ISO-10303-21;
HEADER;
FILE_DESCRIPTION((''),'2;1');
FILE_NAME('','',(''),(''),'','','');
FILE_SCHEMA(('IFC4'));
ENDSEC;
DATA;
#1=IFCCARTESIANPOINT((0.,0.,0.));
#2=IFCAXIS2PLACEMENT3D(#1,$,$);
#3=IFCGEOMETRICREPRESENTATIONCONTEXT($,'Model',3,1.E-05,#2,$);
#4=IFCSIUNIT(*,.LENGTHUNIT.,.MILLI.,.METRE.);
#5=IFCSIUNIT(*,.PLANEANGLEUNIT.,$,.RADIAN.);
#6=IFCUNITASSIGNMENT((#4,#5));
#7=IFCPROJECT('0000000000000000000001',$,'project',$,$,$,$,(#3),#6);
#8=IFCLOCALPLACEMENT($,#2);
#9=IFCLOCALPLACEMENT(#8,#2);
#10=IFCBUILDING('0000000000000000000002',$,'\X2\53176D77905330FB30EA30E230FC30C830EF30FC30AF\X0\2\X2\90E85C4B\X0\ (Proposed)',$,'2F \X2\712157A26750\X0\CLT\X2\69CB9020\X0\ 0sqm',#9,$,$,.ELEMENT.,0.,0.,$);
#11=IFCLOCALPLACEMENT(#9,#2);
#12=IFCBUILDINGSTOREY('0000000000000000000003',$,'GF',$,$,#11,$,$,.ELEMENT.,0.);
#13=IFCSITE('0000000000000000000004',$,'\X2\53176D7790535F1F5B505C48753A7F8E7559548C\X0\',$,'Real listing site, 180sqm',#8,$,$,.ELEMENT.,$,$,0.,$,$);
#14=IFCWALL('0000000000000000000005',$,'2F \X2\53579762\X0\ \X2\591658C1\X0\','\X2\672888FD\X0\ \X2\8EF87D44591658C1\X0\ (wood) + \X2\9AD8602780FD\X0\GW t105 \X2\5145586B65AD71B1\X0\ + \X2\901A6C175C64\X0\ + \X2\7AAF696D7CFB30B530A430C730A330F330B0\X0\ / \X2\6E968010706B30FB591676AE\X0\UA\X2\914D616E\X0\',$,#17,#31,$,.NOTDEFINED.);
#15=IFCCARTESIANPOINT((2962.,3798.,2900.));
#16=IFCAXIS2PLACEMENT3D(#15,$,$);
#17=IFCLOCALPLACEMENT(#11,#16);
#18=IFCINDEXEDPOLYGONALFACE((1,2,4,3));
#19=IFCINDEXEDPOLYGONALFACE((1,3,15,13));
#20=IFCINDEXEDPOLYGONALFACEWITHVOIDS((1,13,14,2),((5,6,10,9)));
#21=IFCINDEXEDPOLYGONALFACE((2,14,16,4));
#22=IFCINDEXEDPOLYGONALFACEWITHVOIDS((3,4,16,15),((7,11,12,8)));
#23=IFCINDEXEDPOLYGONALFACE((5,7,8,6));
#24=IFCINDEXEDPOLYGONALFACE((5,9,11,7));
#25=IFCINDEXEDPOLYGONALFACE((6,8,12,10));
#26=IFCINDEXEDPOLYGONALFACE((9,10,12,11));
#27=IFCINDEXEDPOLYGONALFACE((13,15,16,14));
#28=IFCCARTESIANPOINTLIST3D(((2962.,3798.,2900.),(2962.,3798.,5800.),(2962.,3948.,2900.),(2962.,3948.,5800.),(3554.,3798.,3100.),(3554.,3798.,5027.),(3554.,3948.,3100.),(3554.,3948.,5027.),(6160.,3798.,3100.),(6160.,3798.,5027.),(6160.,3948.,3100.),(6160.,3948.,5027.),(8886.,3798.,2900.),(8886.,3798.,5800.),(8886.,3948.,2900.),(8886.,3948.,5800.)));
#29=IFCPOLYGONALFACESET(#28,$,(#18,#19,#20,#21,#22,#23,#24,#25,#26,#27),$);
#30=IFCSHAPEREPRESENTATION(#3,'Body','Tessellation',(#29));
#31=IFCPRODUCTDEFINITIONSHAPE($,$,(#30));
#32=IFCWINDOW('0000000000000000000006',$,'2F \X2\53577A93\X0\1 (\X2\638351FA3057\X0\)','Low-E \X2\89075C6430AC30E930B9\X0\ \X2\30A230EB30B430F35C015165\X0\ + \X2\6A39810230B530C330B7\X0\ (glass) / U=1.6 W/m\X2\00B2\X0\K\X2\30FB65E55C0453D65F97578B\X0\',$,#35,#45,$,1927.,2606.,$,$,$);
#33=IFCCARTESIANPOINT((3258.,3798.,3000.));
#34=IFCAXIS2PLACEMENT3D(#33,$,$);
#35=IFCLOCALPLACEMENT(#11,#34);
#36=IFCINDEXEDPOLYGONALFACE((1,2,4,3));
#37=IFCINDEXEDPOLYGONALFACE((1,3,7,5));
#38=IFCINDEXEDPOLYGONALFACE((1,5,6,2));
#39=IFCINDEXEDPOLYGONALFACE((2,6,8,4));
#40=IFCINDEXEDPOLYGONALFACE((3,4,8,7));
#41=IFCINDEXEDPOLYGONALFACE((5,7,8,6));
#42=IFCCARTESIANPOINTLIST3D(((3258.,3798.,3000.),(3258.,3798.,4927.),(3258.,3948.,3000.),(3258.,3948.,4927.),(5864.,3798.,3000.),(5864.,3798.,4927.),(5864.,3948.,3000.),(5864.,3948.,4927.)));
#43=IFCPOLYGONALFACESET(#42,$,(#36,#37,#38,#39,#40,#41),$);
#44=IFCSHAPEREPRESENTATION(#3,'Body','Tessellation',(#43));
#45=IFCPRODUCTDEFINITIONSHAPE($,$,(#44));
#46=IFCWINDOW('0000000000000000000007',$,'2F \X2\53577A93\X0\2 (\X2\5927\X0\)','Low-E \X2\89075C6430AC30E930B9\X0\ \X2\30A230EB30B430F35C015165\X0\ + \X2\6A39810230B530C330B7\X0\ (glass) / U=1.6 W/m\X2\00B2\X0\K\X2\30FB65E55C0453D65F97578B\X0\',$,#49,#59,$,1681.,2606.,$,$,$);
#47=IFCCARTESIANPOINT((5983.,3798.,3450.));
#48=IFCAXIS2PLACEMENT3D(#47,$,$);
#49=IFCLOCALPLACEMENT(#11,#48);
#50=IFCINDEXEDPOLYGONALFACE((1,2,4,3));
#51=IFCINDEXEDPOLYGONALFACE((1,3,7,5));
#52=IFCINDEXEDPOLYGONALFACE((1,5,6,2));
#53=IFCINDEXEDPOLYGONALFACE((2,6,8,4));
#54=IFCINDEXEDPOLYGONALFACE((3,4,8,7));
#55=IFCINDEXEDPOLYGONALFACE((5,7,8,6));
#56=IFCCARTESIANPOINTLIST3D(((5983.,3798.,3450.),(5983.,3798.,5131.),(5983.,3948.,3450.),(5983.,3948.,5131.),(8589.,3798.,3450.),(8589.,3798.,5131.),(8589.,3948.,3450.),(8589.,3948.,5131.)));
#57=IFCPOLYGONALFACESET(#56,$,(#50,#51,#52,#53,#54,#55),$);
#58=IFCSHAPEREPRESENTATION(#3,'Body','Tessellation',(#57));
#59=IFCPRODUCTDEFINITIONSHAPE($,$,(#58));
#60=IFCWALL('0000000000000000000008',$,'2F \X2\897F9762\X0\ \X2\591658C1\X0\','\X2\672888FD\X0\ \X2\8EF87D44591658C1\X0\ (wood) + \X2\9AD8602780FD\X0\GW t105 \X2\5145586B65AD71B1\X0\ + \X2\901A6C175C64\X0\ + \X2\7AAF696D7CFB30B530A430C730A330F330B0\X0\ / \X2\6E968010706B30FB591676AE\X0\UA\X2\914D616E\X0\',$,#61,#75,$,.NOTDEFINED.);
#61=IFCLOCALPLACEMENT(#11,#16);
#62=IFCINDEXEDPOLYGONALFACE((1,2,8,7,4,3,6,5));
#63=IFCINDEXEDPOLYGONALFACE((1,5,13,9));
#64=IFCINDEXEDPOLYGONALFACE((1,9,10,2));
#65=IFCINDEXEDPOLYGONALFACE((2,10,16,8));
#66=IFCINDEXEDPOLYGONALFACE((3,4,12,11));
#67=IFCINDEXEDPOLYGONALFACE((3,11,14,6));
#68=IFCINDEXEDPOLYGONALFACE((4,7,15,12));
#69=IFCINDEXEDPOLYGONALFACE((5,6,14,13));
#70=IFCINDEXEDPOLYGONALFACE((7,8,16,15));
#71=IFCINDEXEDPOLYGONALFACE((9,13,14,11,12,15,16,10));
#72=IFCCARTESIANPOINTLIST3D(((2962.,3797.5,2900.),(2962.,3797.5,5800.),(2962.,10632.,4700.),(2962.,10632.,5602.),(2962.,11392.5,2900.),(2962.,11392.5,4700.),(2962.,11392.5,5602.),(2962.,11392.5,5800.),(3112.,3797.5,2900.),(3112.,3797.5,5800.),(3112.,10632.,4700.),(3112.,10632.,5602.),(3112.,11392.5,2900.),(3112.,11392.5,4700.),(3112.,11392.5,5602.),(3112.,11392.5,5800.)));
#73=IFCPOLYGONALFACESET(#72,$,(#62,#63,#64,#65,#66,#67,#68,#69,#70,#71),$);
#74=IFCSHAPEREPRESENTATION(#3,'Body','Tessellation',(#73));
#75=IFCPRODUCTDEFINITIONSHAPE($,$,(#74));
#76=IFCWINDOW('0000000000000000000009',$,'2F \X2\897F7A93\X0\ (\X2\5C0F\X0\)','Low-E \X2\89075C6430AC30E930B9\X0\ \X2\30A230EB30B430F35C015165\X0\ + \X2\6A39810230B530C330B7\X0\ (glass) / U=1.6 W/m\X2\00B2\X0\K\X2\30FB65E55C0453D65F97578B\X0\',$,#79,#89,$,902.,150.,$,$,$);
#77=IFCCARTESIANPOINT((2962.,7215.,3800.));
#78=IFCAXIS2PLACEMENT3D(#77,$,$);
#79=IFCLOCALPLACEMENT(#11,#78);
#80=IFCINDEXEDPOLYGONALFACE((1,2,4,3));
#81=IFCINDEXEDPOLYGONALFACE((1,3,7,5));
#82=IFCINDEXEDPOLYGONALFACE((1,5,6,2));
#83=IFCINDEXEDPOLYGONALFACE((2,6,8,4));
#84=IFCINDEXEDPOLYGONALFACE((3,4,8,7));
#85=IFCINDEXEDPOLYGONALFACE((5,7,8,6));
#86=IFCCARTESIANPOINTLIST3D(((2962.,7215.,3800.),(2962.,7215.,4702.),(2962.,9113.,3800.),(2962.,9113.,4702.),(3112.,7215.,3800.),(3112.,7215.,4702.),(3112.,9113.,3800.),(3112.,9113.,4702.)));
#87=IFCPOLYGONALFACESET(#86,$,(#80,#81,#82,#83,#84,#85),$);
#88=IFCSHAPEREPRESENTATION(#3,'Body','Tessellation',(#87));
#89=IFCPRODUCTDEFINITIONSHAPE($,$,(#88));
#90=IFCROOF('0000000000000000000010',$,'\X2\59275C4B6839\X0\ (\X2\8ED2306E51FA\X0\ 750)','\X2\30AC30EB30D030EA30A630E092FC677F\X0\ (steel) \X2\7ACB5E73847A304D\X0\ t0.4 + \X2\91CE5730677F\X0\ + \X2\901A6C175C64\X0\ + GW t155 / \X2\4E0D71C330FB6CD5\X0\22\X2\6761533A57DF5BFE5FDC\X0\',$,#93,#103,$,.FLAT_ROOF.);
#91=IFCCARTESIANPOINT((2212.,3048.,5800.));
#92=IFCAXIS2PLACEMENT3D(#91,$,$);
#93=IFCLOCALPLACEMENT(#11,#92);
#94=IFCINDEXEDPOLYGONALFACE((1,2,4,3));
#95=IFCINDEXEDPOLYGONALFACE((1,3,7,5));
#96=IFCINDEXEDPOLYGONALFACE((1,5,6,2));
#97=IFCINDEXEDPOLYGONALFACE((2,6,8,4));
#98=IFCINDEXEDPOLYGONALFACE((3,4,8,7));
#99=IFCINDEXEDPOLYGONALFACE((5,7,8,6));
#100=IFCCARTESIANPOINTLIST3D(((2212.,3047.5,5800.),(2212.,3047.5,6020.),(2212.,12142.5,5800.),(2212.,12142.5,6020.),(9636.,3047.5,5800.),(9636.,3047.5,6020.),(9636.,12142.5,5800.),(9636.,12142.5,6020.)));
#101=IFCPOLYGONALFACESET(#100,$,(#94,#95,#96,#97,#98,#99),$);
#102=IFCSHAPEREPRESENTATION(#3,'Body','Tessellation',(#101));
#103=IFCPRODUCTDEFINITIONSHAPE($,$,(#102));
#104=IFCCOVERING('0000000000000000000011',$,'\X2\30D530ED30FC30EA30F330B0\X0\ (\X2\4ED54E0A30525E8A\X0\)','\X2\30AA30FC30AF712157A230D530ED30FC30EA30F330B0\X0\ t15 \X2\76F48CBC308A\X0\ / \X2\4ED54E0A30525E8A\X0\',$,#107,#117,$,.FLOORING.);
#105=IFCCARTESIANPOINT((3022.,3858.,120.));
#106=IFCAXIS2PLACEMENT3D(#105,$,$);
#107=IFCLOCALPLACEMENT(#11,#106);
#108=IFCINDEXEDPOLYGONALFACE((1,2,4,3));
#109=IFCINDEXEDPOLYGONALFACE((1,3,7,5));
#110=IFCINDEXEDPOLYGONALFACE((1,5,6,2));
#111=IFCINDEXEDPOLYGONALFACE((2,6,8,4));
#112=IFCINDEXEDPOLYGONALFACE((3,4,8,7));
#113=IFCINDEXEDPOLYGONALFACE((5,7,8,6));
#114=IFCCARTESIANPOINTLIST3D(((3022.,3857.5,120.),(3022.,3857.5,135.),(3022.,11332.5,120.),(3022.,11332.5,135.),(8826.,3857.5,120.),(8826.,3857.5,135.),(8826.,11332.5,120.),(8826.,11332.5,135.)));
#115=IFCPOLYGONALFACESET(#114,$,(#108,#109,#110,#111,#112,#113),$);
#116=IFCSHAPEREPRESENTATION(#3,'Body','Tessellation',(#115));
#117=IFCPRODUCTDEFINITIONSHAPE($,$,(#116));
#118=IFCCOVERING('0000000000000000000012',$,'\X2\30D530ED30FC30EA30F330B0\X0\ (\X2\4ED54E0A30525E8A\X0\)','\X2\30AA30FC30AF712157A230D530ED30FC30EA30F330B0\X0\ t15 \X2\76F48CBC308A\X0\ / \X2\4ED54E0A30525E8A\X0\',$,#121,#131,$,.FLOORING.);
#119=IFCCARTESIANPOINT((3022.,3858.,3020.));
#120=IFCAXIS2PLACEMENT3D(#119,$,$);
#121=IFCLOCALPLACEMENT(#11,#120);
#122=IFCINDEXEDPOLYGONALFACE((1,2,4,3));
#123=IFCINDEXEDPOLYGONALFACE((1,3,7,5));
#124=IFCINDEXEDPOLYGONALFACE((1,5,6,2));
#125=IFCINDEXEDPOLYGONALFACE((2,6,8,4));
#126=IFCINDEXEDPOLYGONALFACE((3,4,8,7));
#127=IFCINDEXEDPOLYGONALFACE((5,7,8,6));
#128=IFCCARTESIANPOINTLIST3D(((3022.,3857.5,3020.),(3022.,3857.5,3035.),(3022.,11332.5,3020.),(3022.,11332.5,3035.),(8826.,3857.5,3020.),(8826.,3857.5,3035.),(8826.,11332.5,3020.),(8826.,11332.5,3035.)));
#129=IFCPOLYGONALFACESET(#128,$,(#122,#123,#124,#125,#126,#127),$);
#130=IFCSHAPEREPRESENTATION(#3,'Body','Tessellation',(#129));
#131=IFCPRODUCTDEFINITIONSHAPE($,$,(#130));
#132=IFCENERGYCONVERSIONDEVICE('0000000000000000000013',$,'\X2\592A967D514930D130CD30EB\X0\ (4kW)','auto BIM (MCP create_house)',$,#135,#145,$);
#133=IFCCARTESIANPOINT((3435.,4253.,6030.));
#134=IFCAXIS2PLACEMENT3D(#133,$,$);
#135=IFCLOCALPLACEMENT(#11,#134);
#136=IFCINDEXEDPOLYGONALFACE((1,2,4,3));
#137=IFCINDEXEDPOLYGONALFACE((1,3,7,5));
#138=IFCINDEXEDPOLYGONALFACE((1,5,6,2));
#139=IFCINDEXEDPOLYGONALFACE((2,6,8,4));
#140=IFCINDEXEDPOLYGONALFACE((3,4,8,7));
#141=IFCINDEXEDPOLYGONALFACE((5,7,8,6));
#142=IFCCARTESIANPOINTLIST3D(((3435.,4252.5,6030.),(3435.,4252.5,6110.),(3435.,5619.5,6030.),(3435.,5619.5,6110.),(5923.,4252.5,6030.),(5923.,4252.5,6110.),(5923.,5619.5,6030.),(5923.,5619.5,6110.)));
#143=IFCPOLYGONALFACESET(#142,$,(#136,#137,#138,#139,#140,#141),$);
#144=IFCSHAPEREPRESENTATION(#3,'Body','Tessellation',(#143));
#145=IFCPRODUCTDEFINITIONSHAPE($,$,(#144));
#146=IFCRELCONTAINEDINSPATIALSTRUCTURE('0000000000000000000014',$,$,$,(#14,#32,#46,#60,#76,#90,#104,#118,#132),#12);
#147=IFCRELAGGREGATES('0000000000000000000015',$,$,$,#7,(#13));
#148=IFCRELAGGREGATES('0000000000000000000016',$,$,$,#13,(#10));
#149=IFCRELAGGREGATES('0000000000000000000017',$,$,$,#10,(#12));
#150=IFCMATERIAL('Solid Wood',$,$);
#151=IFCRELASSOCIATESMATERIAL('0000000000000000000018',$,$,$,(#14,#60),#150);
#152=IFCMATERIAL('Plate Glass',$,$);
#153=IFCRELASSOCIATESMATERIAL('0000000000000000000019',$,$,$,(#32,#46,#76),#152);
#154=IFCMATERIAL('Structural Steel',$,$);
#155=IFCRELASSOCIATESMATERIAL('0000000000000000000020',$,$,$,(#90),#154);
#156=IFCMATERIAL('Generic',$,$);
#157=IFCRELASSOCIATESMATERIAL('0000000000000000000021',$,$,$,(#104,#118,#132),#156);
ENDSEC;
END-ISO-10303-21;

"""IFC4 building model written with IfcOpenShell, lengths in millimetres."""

from ifc_helpers import new_model, si_unit, frame, frame_2d, origin, place, context, project, spatial, rectangle, extrude, material, element, fill, save


model = new_model("IFC4")

# Units and contexts
model_context = context("Model", 3, precision=1e-05, world=origin())
ifc_project = project(units=[si_unit("LENGTHUNIT", "METRE", prefix="MILLI"), si_unit("PLANEANGLEUNIT", "RADIAN")], contexts=[model_context])

# Site, building, storey
site_placement = place(None, origin())
site = spatial("IfcSite", under=ifc_project, at=site_placement, Name="北海道弟子屈町美留和", ObjectType="Real listing site, 180sqm", CompositionType="ELEMENT", RefElevation=0.0)
building_placement = place(site_placement, origin())
building = spatial("IfcBuilding", under=site, at=building_placement, Name="北海道・リモートワーク2部屋 (Proposed)", ObjectType="2F 無垢材CLT構造 0sqm", CompositionType="ELEMENT", ElevationOfRefHeight=0.0, ElevationOfTerrain=0.0)
storey_placement = place(building_placement, origin())
storey = spatial("IfcBuildingStorey", under=building, at=storey_placement, Name="GF", CompositionType="ELEMENT", Elevation=0.0)

# Shared definitions
ifc_material_1 = material(Name="Solid Wood")

# Shared definitions
ifc_material_2 = material(Name="Plate Glass")

# Wall, openings, windows
wall_1_placement = place(storey_placement, frame((2962.0, 3798.0, 2900.0)))
wall_1 = element("IfcWall", 1, at=wall_1_placement, inside=storey, material=ifc_material_1, Name="2F 南面 外壁", Description="木製 軸組外壁 (wood) + 高性能GW t105 充填断熱 + 通気層 + 窯業系サイディング / 準耐火・外皮UA配慮", PredefinedType="NOTDEFINED", context=model_context, shape_type="SweptSolid", body=[
    extrude(rectangle(XDim=5924.0, YDim=150.0, at=frame_2d((2962.0, 75.0))), frame((2962.0, 3798.0, 2900.0)), (0.0, 0.0, 1.0), 2900.0),
])
opening_1_placement = place(storey_placement, frame((3258.0, 3798.0, 3000.0)))
opening_1 = element("IfcOpeningElement", 2, at=opening_1_placement, cuts=wall_1, PredefinedType="NOTDEFINED", context=model_context, shape_type="SweptSolid", body=[
    extrude(rectangle(XDim=2606.0, YDim=150.0, at=frame_2d((1303.0, 75.0))), frame((3258.0, 3798.0, 3000.0)), (0.0, 0.0, 1.0), 1927.0),
])
opening_2_placement = place(storey_placement, frame((5983.0, 3798.0, 3450.0)))
opening_2 = element("IfcOpeningElement", 3, at=opening_2_placement, cuts=wall_1, PredefinedType="NOTDEFINED", context=model_context, shape_type="SweptSolid", body=[
    extrude(rectangle(XDim=2606.0, YDim=150.0, at=frame_2d((1303.0, 75.0))), frame((5983.0, 3798.0, 3450.0)), (0.0, 0.0, 1.0), 1681.0),
])
window_1_placement = place(storey_placement, frame((3258.0, 3798.0, 3000.0)))
window_1 = element("IfcWindow", 4, at=window_1_placement, inside=storey, material=ifc_material_2, Name="2F 南窓1 (掃出し)", Description="Low-E 複層ガラス アルゴン封入 + 樹脂サッシ (glass) / U=1.6 W/m²K・日射取得型", OverallHeight=1927.0, OverallWidth=2606.0, context=model_context, shape_type="SweptSolid", body=[
    extrude(rectangle(XDim=2606.0, YDim=150.0, at=frame_2d((1303.0, 75.0))), frame((3258.0, 3798.0, 3000.0)), (0.0, 0.0, 1.0), 1927.0),
])
fill(opening_1, window_1)
window_2_placement = place(storey_placement, frame((5983.0, 3798.0, 3450.0)))
window_2 = element("IfcWindow", 5, at=window_2_placement, inside=storey, material=ifc_material_2, Name="2F 南窓2 (大)", Description="Low-E 複層ガラス アルゴン封入 + 樹脂サッシ (glass) / U=1.6 W/m²K・日射取得型", OverallHeight=1681.0, OverallWidth=2606.0, context=model_context, shape_type="SweptSolid", body=[
    extrude(rectangle(XDim=2606.0, YDim=150.0, at=frame_2d((1303.0, 75.0))), frame((5983.0, 3798.0, 3450.0)), (0.0, 0.0, 1.0), 1681.0),
])
fill(opening_2, window_2)

# Wall, opening, window
wall_2_placement = place(storey_placement, frame((2962.0, 3798.0, 2900.0)))
wall_2 = element("IfcWall", 6, at=wall_2_placement, inside=storey, material=ifc_material_1, Name="2F 西面 外壁", Description="木製 軸組外壁 (wood) + 高性能GW t105 充填断熱 + 通気層 + 窯業系サイディング / 準耐火・外皮UA配慮", PredefinedType="NOTDEFINED", context=model_context, shape_type="SweptSolid", body=[
    extrude(rectangle(XDim=150.0, YDim=7595.0, at=frame_2d((75.0, 3797.0))), frame((2962.0, 3798.0, 2900.0)), (0.0, 0.0, 1.0), 2900.0),
])
opening_3_placement = place(storey_placement, frame((2962.0, 7215.0, 3800.0)))
opening_3 = element("IfcOpeningElement", 7, at=opening_3_placement, cuts=wall_2, PredefinedType="NOTDEFINED", context=model_context, shape_type="SweptSolid", body=[
    extrude(rectangle(XDim=150.0, YDim=1898.0, at=frame_2d((75.0, 949.0))), frame((2962.0, 7215.0, 3800.0)), (0.0, 0.0, 1.0), 902.0),
])
window_3_placement = place(storey_placement, frame((2962.0, 7215.0, 3800.0)))
window_3 = element("IfcWindow", 8, at=window_3_placement, inside=storey, material=ifc_material_2, Name="2F 西窓 (小)", Description="Low-E 複層ガラス アルゴン封入 + 樹脂サッシ (glass) / U=1.6 W/m²K・日射取得型", OverallHeight=902.0, OverallWidth=150.0, context=model_context, shape_type="SweptSolid", body=[
    extrude(rectangle(XDim=150.0, YDim=1898.0, at=frame_2d((75.0, 949.0))), frame((2962.0, 7215.0, 3800.0)), (0.0, 0.0, 1.0), 902.0),
])
fill(opening_3, window_3)

# Roof
ifc_material_3 = material(Name="Structural Steel")
roof_placement = place(storey_placement, frame((2212.0, 3048.0, 5800.0)))
element("IfcRoof", 9, at=roof_placement, inside=storey, material=ifc_material_3, Name="大屋根 (軒の出 750)", Description="ガルバリウム鋼板 (steel) 立平葺き t0.4 + 野地板 + 通気層 + GW t155 / 不燃・法22条区域対応", PredefinedType="FLAT_ROOF", context=model_context, shape_type="SweptSolid", body=[
    extrude(rectangle(XDim=7424.0, YDim=9095.0, at=frame_2d((3712.0, 4547.0))), frame((2212.0, 3048.0, 5800.0)), (0.0, 0.0, 1.0), 220.0),
])

# Coverings
ifc_material_4 = material(Name="Generic")
covering_1_placement = place(storey_placement, frame((3022.0, 3858.0, 120.0)))
element("IfcCovering", 10, at=covering_1_placement, inside=storey, material=ifc_material_4, Name="フローリング (仕上げ床)", Description="オーク無垢フローリング t15 直貼り / 仕上げ床", PredefinedType="FLOORING", context=model_context, shape_type="SweptSolid", body=[
    extrude(rectangle(XDim=5804.0, YDim=7475.0, at=frame_2d((2902.0, 3737.0))), frame((3022.0, 3858.0, 120.0)), (0.0, 0.0, 1.0), 15.0),
])
covering_2_placement = place(storey_placement, frame((3022.0, 3858.0, 3020.0)))
element("IfcCovering", 11, at=covering_2_placement, inside=storey, material=ifc_material_4, Name="フローリング (仕上げ床)", Description="オーク無垢フローリング t15 直貼り / 仕上げ床", PredefinedType="FLOORING", context=model_context, shape_type="SweptSolid", body=[
    extrude(rectangle(XDim=5804.0, YDim=7475.0, at=frame_2d((2902.0, 3737.0))), frame((3022.0, 3858.0, 3020.0)), (0.0, 0.0, 1.0), 15.0),
])

# Energy conversion device
energy_conversion_device_placement = place(storey_placement, frame((3435.0, 4253.0, 6030.0)))
element("IfcEnergyConversionDevice", 12, at=energy_conversion_device_placement, inside=storey, material=ifc_material_4, Name="太陽光パネル (4kW)", Description="auto BIM (MCP create_house)", context=model_context, shape_type="SweptSolid", body=[
    extrude(rectangle(XDim=2488.0, YDim=1367.0, at=frame_2d((1244.0, 683.0))), frame((3435.0, 4253.0, 6030.0)), (0.0, 0.0, 1.0), 80.0),
])

save(model, "model.ifc")
